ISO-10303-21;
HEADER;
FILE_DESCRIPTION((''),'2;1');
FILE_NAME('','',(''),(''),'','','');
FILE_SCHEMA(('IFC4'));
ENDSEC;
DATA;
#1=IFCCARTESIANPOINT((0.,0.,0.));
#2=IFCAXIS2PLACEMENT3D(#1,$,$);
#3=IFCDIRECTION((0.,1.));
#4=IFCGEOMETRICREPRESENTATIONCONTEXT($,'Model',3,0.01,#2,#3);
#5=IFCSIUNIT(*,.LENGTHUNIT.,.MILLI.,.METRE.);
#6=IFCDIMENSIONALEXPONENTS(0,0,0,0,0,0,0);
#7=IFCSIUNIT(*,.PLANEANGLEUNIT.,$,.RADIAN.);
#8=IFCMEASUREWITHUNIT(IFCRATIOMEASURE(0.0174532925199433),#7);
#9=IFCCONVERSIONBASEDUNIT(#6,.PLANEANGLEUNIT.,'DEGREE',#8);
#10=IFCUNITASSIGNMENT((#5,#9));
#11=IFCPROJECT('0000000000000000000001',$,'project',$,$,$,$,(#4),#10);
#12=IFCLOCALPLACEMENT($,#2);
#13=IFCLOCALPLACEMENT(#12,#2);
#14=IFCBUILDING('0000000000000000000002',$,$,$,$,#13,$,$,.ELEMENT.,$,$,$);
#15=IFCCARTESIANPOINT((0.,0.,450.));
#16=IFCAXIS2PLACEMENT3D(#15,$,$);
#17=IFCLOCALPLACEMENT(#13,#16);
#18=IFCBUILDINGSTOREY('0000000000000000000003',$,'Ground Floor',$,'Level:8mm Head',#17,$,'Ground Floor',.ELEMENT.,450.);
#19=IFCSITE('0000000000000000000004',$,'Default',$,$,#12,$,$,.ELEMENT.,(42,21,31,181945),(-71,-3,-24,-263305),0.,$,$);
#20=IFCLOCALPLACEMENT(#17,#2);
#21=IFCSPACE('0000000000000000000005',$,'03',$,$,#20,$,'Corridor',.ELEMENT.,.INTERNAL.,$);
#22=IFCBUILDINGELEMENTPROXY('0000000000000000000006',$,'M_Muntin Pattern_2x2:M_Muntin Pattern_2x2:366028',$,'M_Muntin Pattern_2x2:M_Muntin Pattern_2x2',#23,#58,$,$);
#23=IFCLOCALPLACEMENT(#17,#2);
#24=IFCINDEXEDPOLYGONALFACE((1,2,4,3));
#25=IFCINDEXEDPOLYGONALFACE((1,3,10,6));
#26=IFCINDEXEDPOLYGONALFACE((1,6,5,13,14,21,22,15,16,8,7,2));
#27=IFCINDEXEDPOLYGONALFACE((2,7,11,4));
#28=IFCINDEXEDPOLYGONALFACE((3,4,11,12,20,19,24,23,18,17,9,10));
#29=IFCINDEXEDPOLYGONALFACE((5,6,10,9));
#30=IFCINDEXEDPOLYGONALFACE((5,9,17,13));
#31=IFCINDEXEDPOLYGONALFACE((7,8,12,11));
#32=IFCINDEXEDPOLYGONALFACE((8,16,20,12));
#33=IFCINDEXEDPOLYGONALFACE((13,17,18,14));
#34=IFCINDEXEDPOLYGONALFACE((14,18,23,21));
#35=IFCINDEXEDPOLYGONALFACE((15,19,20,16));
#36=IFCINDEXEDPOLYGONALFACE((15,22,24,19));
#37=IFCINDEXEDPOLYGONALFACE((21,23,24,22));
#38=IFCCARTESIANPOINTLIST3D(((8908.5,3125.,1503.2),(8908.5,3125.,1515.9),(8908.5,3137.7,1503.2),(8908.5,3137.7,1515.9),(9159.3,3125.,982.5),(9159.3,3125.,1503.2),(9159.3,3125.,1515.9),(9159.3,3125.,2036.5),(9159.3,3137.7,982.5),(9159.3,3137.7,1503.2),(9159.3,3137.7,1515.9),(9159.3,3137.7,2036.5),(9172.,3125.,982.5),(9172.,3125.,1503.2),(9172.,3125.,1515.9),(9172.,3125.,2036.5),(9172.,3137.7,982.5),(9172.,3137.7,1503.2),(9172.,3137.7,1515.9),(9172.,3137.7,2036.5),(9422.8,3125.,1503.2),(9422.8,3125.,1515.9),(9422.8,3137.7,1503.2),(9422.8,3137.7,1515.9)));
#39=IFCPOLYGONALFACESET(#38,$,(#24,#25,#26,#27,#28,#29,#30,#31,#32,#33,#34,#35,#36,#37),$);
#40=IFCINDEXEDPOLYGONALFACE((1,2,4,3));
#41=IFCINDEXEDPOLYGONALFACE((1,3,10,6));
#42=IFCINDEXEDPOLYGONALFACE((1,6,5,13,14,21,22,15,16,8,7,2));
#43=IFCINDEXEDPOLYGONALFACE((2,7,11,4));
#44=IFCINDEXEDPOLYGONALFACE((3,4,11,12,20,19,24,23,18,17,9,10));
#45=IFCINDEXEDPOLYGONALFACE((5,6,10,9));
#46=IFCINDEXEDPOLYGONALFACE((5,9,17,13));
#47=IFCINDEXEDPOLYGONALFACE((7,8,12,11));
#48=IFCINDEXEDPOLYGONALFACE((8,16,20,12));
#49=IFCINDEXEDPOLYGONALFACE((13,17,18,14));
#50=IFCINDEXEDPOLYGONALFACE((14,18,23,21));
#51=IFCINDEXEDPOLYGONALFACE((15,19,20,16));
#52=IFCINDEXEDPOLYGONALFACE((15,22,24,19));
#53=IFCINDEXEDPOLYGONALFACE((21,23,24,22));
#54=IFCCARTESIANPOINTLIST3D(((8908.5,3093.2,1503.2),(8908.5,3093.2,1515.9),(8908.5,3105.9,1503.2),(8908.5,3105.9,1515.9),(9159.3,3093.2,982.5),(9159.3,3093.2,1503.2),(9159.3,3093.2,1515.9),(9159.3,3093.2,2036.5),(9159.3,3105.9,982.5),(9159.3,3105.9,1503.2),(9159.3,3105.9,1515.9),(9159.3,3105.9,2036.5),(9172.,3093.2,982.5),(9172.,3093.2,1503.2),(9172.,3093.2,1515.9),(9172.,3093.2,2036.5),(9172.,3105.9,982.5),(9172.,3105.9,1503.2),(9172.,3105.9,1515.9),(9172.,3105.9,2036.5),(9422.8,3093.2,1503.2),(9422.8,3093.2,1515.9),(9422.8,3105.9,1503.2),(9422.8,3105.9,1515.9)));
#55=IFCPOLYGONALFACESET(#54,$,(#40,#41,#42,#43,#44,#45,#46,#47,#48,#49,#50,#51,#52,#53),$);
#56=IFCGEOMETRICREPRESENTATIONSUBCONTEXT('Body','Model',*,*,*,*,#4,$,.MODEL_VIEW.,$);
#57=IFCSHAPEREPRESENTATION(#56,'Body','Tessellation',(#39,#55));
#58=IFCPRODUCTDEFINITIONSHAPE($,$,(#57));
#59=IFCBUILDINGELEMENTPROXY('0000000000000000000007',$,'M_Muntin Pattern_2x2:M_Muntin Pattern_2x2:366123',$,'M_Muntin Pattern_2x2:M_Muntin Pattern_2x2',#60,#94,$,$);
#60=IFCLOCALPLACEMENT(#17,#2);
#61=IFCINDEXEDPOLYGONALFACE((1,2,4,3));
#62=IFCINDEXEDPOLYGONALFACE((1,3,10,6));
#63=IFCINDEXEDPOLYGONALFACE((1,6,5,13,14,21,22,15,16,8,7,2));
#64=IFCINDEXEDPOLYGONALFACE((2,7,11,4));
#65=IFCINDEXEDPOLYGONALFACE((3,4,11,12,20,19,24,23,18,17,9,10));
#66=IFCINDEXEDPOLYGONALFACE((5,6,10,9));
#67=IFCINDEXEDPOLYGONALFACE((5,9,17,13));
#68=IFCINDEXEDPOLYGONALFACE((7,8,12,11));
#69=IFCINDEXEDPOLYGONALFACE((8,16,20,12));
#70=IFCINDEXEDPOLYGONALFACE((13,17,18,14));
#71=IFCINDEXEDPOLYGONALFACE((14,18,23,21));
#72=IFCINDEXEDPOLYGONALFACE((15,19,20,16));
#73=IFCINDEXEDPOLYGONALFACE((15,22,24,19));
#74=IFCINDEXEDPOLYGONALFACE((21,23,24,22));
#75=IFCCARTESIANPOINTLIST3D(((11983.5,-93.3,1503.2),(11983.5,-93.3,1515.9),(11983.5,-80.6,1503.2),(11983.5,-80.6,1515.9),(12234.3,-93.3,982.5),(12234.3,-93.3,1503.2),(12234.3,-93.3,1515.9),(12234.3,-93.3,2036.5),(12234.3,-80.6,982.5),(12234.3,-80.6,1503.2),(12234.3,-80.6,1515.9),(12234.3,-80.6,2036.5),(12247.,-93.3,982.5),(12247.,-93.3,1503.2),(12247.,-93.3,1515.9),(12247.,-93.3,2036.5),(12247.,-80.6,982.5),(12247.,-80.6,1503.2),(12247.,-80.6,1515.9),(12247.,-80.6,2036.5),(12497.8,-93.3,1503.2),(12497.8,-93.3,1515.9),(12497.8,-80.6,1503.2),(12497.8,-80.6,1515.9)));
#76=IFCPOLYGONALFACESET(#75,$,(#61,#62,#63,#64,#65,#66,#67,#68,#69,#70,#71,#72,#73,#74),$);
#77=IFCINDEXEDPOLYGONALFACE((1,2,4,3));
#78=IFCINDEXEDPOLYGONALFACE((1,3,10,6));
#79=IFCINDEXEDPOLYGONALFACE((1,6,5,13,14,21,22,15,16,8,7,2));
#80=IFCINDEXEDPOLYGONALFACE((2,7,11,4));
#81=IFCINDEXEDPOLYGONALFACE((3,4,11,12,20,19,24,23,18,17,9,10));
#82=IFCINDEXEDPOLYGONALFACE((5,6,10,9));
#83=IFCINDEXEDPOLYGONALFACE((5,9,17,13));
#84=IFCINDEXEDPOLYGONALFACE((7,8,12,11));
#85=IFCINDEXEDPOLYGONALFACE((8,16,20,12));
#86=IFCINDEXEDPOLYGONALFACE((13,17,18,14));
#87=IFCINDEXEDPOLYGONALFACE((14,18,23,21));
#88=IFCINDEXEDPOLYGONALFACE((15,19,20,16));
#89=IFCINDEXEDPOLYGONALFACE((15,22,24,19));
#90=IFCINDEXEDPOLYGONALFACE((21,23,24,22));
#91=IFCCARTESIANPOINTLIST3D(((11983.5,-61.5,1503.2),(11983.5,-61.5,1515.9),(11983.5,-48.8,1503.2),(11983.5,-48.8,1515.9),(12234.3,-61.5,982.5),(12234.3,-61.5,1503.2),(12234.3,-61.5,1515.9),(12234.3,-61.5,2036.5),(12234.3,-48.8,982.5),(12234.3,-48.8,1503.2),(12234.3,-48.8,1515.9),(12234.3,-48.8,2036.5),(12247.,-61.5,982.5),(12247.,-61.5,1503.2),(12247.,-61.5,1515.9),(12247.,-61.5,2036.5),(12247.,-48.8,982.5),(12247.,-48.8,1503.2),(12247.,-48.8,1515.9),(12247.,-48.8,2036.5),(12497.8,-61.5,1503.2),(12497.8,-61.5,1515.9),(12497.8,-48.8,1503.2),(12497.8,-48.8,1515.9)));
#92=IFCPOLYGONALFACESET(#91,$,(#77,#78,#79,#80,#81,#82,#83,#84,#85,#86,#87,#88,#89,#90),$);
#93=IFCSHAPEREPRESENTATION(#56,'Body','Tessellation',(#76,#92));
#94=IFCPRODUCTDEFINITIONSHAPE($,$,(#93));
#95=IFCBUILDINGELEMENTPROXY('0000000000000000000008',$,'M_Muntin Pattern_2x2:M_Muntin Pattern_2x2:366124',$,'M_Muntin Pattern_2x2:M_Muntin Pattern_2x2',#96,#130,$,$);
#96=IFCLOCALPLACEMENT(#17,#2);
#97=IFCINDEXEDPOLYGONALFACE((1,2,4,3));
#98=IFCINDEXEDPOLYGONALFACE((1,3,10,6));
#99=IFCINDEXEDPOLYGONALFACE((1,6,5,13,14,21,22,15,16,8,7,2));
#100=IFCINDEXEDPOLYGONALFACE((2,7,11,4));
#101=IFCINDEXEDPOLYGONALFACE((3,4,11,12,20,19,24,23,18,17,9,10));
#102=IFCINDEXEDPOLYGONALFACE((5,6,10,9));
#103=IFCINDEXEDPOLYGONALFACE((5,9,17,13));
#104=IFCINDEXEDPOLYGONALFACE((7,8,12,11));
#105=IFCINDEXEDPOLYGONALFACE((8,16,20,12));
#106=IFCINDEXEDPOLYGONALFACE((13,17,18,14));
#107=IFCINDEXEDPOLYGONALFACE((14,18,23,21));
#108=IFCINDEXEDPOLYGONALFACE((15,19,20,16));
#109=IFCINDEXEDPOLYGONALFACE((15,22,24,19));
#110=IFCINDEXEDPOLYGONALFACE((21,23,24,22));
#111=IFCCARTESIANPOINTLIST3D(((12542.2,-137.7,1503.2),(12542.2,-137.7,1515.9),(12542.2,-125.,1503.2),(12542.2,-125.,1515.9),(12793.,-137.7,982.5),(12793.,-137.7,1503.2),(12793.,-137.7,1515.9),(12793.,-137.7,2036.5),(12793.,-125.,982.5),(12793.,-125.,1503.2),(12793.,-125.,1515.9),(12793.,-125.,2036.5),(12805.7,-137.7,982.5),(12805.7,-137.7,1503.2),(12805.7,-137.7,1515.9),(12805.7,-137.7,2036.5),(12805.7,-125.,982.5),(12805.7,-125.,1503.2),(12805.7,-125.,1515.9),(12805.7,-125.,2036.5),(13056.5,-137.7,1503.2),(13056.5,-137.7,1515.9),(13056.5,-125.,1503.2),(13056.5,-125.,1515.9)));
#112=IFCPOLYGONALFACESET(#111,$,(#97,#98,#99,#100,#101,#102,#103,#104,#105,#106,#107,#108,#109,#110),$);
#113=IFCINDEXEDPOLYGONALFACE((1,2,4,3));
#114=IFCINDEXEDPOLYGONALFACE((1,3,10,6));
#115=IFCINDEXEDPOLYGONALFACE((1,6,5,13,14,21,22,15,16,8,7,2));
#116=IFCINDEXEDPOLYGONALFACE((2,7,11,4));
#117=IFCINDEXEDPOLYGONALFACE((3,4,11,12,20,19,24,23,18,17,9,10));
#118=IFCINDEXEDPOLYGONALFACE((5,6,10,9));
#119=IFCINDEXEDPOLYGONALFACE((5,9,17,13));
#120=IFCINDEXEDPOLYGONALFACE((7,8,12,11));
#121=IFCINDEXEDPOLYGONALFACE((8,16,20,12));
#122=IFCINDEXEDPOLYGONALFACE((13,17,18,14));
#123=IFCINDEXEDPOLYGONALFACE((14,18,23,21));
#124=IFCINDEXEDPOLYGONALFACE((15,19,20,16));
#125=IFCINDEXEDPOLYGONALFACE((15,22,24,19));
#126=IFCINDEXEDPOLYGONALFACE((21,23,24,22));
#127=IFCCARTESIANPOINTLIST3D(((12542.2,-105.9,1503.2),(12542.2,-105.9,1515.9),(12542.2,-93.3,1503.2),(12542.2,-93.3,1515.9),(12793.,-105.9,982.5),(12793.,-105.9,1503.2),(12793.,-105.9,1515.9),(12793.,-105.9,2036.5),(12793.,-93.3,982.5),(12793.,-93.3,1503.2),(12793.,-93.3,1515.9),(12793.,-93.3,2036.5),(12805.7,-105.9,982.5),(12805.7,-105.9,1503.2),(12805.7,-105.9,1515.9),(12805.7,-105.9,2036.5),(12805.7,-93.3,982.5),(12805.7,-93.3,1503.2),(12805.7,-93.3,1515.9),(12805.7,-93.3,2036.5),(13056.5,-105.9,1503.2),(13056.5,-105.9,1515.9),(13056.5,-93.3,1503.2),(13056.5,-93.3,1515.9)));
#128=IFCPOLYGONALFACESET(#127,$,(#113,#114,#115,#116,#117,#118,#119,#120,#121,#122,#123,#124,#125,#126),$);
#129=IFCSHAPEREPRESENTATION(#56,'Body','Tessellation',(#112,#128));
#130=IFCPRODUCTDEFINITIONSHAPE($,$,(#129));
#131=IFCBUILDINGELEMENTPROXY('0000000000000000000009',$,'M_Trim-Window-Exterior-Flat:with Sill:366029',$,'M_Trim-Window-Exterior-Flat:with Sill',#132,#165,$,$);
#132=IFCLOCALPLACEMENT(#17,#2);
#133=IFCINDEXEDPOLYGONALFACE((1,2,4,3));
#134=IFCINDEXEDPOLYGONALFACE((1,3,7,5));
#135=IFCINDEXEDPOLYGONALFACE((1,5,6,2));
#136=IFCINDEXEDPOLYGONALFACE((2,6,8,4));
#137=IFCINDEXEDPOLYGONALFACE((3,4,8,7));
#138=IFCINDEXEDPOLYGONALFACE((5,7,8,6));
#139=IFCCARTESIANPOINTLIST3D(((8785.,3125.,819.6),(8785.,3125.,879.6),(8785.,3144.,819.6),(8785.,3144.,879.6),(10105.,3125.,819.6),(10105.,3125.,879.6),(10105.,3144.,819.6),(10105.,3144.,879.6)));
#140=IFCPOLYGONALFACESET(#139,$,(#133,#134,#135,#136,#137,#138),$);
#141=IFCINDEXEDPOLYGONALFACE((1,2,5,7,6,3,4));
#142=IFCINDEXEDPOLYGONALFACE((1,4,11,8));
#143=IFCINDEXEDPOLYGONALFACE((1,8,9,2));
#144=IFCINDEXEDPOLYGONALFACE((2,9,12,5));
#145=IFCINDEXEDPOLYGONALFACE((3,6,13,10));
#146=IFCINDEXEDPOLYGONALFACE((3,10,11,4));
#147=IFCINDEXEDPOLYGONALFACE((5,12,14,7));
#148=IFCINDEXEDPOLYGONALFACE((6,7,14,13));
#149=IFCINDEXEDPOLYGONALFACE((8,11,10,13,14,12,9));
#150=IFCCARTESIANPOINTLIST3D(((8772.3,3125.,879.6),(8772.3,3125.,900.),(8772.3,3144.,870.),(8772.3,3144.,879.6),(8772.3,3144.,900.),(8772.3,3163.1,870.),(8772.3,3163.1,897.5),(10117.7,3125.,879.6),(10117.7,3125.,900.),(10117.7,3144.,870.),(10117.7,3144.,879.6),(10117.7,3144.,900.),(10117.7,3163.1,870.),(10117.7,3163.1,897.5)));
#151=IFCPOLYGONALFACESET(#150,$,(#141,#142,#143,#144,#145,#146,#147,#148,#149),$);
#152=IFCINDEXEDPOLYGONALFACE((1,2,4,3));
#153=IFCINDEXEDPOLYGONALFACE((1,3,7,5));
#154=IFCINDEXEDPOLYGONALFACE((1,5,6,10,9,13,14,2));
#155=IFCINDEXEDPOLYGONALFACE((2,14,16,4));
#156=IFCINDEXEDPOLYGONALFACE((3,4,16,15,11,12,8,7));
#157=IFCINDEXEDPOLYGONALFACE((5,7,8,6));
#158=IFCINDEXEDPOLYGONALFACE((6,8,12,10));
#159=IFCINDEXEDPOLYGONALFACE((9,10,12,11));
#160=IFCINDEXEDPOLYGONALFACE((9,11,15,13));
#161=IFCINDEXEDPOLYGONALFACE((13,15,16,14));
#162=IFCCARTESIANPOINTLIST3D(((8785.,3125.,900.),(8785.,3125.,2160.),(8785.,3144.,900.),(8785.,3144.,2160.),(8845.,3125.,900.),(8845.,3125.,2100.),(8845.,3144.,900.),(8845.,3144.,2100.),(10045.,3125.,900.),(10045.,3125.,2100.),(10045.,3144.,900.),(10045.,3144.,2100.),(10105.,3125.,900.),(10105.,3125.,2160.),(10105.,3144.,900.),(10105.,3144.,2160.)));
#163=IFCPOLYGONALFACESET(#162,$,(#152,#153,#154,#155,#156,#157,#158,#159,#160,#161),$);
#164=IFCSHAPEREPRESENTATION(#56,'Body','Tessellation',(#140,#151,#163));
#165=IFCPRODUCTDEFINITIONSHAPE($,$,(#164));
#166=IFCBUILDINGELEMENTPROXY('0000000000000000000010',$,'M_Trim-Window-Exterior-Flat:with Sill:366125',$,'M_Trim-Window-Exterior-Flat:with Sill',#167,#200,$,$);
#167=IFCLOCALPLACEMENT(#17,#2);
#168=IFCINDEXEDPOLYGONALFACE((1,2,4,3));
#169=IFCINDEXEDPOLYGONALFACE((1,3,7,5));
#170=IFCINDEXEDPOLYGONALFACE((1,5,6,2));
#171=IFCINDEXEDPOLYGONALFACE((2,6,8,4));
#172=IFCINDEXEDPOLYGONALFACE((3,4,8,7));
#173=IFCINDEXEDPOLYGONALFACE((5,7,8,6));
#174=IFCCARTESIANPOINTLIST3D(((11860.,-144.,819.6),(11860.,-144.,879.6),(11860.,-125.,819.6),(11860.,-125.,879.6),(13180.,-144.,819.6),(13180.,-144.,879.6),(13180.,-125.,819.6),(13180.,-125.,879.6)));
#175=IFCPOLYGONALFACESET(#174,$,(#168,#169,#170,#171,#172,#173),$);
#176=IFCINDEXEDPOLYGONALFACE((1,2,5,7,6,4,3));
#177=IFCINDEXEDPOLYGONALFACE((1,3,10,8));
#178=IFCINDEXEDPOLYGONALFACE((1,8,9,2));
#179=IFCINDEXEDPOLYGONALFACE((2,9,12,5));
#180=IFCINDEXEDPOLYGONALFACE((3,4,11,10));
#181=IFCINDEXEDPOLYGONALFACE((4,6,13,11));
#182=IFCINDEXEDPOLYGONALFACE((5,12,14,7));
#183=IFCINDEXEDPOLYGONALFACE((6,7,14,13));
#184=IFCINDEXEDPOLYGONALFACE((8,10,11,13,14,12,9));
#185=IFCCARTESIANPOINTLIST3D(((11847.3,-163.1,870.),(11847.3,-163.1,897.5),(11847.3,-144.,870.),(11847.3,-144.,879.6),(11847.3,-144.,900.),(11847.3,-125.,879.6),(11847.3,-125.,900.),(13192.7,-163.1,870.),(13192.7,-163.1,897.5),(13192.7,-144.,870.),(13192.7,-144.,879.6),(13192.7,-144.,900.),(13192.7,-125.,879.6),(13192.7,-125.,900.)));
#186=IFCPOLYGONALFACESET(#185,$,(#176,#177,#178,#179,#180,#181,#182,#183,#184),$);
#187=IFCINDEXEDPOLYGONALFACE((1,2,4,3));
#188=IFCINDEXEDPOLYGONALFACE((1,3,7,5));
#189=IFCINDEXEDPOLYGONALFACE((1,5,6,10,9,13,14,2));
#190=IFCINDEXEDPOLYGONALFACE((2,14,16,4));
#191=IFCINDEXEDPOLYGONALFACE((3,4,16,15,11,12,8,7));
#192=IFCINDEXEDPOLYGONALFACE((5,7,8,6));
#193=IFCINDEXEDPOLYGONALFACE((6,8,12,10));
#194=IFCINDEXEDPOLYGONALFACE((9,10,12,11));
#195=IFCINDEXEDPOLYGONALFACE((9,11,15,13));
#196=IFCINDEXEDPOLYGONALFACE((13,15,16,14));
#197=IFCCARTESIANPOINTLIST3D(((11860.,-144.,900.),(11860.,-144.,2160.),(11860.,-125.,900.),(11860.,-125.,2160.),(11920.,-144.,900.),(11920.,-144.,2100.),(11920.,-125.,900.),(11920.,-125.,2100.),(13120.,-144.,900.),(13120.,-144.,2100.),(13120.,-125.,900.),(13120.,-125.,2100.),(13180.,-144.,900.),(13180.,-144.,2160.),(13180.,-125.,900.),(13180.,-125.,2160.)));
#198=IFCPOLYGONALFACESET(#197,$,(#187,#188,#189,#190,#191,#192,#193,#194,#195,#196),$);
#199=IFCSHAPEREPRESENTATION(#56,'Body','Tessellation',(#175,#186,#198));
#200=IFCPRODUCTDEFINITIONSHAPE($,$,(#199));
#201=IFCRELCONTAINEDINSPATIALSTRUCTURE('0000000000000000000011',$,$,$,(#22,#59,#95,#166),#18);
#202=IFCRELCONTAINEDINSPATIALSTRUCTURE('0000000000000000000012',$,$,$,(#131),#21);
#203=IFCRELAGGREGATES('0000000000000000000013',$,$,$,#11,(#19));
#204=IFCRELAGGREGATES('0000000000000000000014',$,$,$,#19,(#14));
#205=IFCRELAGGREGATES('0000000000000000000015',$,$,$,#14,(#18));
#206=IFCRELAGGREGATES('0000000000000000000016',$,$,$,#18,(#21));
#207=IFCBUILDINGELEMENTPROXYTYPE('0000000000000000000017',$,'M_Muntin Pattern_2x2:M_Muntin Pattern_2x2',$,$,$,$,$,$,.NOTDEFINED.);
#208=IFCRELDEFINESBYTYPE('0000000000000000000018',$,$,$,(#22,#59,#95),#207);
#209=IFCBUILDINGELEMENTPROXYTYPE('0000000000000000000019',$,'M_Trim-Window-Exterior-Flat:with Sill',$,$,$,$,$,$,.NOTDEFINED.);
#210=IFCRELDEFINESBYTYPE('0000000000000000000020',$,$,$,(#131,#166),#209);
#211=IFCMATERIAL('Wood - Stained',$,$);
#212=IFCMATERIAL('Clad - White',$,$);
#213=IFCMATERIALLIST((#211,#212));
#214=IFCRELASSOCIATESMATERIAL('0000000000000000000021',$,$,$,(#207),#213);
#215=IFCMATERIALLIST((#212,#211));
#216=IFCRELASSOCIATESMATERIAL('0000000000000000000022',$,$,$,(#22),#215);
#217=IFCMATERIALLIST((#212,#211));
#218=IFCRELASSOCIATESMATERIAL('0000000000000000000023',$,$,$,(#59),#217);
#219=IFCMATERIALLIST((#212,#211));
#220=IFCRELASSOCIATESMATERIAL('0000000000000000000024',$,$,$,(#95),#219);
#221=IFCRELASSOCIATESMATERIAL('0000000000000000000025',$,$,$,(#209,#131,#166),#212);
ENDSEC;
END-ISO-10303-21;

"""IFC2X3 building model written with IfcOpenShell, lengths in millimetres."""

from ifc_helpers import new_model, entity, si_unit, converted_unit, direction, frame, frame_2d, origin, place, context, subcontext, project, spatial, polyline, rectangle, outline, extrude, source, transform, mapped, material, material_list, type_object, type_shapes, element, save


model = new_model("IFC2X3")

# Units and contexts
model_context = context("Model", 3, precision=0.01, world=origin(), true_north=direction((0.0, 1.0)))
body_context = subcontext(model_context, "Body", "Model", "MODEL_VIEW")
ifc_project = project(units=[si_unit("LENGTHUNIT", "METRE", prefix="MILLI"), converted_unit("PLANEANGLEUNIT", "DEGREE", entity("IfcRatioMeasure", 0.0174532925199433), si_unit("PLANEANGLEUNIT", "RADIAN"), dimensions=[0, 0, 0, 0, 0, 0, 0])], contexts=[model_context])

# Site, building, storey
site_placement = place(None, origin())
site = spatial("IfcSite", under=ifc_project, at=site_placement, Name="Default", CompositionType="ELEMENT", RefLatitude=(42, 21, 31, 181945), RefLongitude=(-71, -3, -24, -263305), RefElevation=0.0)
building_placement = place(site_placement, origin())
building = spatial("IfcBuilding", under=site, at=building_placement, CompositionType="ELEMENT")
storey_placement = place(building_placement, frame((0.0, 0.0, 450.0)))
storey = spatial("IfcBuildingStorey", under=building, at=storey_placement, Name="Ground Floor", ObjectType="Level:8mm Head", LongName="Ground Floor", CompositionType="ELEMENT", Elevation=450.0)

# Building element proxies
ifc_material_1 = material(Name="Clad - White")
ifc_material_2 = material(Name="Wood - Stained")
ifc_material_list_1 = material_list([ifc_material_2, ifc_material_1])
building_element_proxy_type_1 = type_object("IfcBuildingElementProxyType", Name="M_Muntin Pattern_2x2:M_Muntin Pattern_2x2", PredefinedType="NOTDEFINED", material=ifc_material_list_1)
shared_shape_1 = source(origin(), body_context, "Body", "SweptSolid", [
    extrude(outline(polyline([(6.4, -6.4), (527.0, -6.4), (527.0, 6.3), (6.4, 6.3), (6.4, 257.1), (-6.3, 257.1), (-6.3, 6.3), (-527.0, 6.3), (-527.0, -6.4), (-6.3, -6.4), (-6.3, -257.1), (6.4, -257.1), (6.4, -6.4)])), frame((0.0, 9.5, 527.0), z_axis=(0.0, 1.0, 0.0), x_axis=(0.0, 0.0, 1.0)), (0.0, 0.0, 1.0), 12.7),
    extrude(outline(polyline([(6.4, -6.4), (527.0, -6.4), (527.0, 6.3), (6.4, 6.3), (6.4, 257.1), (-6.3, 257.1), (-6.3, 6.3), (-527.0, 6.3), (-527.0, -6.4), (-6.3, -6.4), (-6.3, -257.1), (6.4, -257.1), (6.4, -6.4)])), frame((0.0, -22.2, 527.0), z_axis=(0.0, 1.0, 0.0), x_axis=(0.0, 0.0, 1.0)), (0.0, 0.0, 1.0), 12.7),
])
type_shapes(building_element_proxy_type_1, [shared_shape_1])
ifc_material_list_2 = material_list([ifc_material_1, ifc_material_2])
proxy_1_placement = place(storey_placement, frame((9165.6, 3115.5, 982.5)))
element("IfcBuildingElementProxy", 1, at=proxy_1_placement, inside=storey, type_object=building_element_proxy_type_1, material=ifc_material_list_2, Name="M_Muntin Pattern_2x2:M_Muntin Pattern_2x2:366028", ObjectType="M_Muntin Pattern_2x2:M_Muntin Pattern_2x2", context=body_context, shape_type="MappedRepresentation", body=[
    mapped(shared_shape_1, transform((0.0, 0.0, 0.0), scale=1.0)),
])
ifc_material_list_3 = material_list([ifc_material_1, ifc_material_2])
proxy_2_placement = place(storey_placement, frame((12240.6, -71.0, 982.5), z_axis=(0.0, 0.0, 1.0), x_axis=(-1.0, 0.0, 0.0)))
element("IfcBuildingElementProxy", 2, at=proxy_2_placement, inside=storey, type_object=building_element_proxy_type_1, material=ifc_material_list_3, Name="M_Muntin Pattern_2x2:M_Muntin Pattern_2x2:366123", ObjectType="M_Muntin Pattern_2x2:M_Muntin Pattern_2x2", context=body_context, shape_type="MappedRepresentation", body=[
    mapped(shared_shape_1, transform((0.0, 0.0, 0.0), scale=1.0)),
])
ifc_material_list_4 = material_list([ifc_material_1, ifc_material_2])
proxy_3_placement = place(storey_placement, frame((12799.4, -115.5, 982.5), z_axis=(0.0, 0.0, 1.0), x_axis=(-1.0, 0.0, 0.0)))
element("IfcBuildingElementProxy", 3, at=proxy_3_placement, inside=storey, type_object=building_element_proxy_type_1, material=ifc_material_list_4, Name="M_Muntin Pattern_2x2:M_Muntin Pattern_2x2:366124", ObjectType="M_Muntin Pattern_2x2:M_Muntin Pattern_2x2", context=body_context, shape_type="MappedRepresentation", body=[
    mapped(shared_shape_1, transform((0.0, 0.0, 0.0), scale=1.0)),
])

# Shared definitions
space_1_placement = place(storey_placement, origin())
space_1 = spatial("IfcSpace", under=storey, at=space_1_placement, Name="03", LongName="Corridor", CompositionType="ELEMENT", InteriorOrExteriorSpace="INTERNAL")

# Building element proxies
building_element_proxy_type_2 = type_object("IfcBuildingElementProxyType", Name="M_Trim-Window-Exterior-Flat:with Sill", PredefinedType="NOTDEFINED", material=ifc_material_1)
shared_shape_2 = source(origin(), body_context, "Body", "SweptSolid", [
    extrude(rectangle(XDim=1320.0, YDim=60.0, at=frame_2d((0.0, 0.0), x_axis=(1.0, 0.0))), frame((0.0, -1250.4, 0.0), z_axis=(0.0, 0.0, 1.0), x_axis=(-1.0, 0.0, 0.0)), (0.0, 0.0, 1.0), 19.1),
    extrude(outline(polyline([(-19.0, -15.2), (0.0, -15.2), (0.0, -5.7), (19.0, -5.7), (19.0, 14.8), (0.0, 14.8), (-19.0, 12.3), (-19.0, -15.2)])), frame((-672.7, -1214.8, 19.0), z_axis=(1.0, 0.0, 0.0), x_axis=(0.0, 0.0, -1.0)), (0.0, 0.0, 1.0), 1345.4),
    extrude(outline(polyline([(-645.0, -660.0), (615.0, -660.0), (615.0, -600.0), (-585.0, -600.0), (-585.0, 600.0), (615.0, 600.0), (615.0, 660.0), (-645.0, 660.0), (-645.0, -660.0)])), frame((0.0, -585.0, 0.0), z_axis=(0.0, 0.0, 1.0), x_axis=(0.0, -1.0, 0.0)), (0.0, 0.0, 1.0), 19.1),
])
type_shapes(building_element_proxy_type_2, [shared_shape_2])
proxy_4_placement = place(space_1_placement, frame((9445.0, 3125.0, 2100.0), z_axis=(0.0, 1.0, 0.0), x_axis=(-1.0, 0.0, 0.0)))
element("IfcBuildingElementProxy", 4, at=proxy_4_placement, inside=space_1, type_object=building_element_proxy_type_2, material=ifc_material_1, Name="M_Trim-Window-Exterior-Flat:with Sill:366029", ObjectType="M_Trim-Window-Exterior-Flat:with Sill", context=body_context, shape_type="MappedRepresentation", body=[
    mapped(shared_shape_2, transform((0.0, 0.0, 0.0), scale=1.0)),
])
proxy_5_placement = place(storey_placement, frame((12520.0, -125.0, 2100.0), z_axis=(0.0, -1.0, 0.0), x_axis=(1.0, 0.0, 0.0)))
element("IfcBuildingElementProxy", 5, at=proxy_5_placement, inside=storey, type_object=building_element_proxy_type_2, material=ifc_material_1, Name="M_Trim-Window-Exterior-Flat:with Sill:366125", ObjectType="M_Trim-Window-Exterior-Flat:with Sill", context=body_context, shape_type="MappedRepresentation", body=[
    mapped(shared_shape_2, transform((0.0, 0.0, 0.0), scale=1.0)),
])

save(model, "model.ifc")
